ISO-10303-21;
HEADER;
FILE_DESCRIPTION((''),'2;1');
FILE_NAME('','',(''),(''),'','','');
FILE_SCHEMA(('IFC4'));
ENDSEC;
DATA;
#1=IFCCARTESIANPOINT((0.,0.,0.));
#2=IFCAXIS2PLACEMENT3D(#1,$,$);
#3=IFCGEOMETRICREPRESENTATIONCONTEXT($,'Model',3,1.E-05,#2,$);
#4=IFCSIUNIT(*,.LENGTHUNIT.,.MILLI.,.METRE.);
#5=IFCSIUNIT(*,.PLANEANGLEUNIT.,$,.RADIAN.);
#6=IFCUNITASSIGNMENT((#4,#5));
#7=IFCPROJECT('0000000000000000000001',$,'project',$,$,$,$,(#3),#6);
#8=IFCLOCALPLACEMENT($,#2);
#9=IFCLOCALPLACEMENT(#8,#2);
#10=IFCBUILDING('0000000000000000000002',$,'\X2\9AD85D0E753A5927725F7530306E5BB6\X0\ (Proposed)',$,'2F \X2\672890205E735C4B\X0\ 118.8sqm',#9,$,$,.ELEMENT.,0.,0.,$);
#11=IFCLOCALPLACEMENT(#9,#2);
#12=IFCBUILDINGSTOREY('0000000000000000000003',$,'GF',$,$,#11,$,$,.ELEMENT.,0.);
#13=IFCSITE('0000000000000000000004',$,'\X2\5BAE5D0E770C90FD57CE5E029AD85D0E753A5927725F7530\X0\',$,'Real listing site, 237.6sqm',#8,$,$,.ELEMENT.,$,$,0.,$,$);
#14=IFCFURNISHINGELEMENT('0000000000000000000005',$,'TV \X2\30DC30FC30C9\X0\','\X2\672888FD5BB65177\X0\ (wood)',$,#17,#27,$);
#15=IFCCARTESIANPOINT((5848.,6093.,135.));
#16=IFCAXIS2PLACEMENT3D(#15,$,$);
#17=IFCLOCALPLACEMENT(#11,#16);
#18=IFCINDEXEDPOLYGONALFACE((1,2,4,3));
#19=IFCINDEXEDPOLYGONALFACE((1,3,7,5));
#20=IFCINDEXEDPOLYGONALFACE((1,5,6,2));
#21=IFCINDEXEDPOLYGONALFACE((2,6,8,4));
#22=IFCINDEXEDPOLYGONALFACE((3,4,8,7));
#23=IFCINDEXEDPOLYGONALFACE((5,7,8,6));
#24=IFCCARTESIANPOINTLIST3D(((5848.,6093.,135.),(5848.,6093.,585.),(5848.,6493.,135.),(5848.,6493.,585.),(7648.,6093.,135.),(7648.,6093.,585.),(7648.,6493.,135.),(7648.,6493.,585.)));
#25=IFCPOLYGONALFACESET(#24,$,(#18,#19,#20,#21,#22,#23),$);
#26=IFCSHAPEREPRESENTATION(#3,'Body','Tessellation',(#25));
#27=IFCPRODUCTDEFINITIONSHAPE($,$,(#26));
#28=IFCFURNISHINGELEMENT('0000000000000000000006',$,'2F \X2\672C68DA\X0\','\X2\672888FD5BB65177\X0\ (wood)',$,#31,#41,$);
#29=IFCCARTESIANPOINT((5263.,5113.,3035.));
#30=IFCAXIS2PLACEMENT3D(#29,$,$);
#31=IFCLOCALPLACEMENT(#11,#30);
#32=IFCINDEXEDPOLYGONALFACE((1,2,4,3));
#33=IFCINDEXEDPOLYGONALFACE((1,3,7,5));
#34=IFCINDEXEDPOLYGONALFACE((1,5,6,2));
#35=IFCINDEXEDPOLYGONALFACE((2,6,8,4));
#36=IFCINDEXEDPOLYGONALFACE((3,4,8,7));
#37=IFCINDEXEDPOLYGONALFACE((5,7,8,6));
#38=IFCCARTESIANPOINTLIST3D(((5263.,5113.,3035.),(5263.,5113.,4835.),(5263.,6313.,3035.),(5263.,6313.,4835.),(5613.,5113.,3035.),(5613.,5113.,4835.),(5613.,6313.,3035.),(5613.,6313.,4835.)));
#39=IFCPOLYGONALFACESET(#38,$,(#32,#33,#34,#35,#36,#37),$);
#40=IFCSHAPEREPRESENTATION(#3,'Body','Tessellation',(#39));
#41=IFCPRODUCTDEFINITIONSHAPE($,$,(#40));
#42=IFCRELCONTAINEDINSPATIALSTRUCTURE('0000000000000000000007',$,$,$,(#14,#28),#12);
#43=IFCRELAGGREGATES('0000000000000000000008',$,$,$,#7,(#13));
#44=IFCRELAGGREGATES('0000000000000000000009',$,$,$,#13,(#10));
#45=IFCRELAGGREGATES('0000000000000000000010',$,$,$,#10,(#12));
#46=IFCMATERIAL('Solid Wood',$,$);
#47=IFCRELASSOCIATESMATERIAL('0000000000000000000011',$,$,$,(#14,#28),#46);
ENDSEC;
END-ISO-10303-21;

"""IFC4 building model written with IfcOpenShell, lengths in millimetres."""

from ifc_helpers import new_model, si_unit, frame, frame_2d, origin, place, context, project, spatial, rectangle, extrude, material, element, save


model = new_model("IFC4")

# Units and contexts
model_context = context("Model", 3, precision=1e-05, world=origin())
ifc_project = project(units=[si_unit("LENGTHUNIT", "METRE", prefix="MILLI"), si_unit("PLANEANGLEUNIT", "RADIAN")], contexts=[model_context])

# Site, building, storey
site_placement = place(None, origin())
site = spatial("IfcSite", under=ifc_project, at=site_placement, Name="宮崎県都城市高崎町大牟田", ObjectType="Real listing site, 237.6sqm", CompositionType="ELEMENT", RefElevation=0.0)
building_placement = place(site_placement, origin())
building = spatial("IfcBuilding", under=site, at=building_placement, Name="高崎町大牟田の家 (Proposed)", ObjectType="2F 木造平屋 118.8sqm", CompositionType="ELEMENT", ElevationOfRefHeight=0.0, ElevationOfTerrain=0.0)
storey_placement = place(building_placement, origin())
storey = spatial("IfcBuildingStorey", under=building, at=storey_placement, Name="GF", CompositionType="ELEMENT", Elevation=0.0)

# Shared definitions
ifc_material_1 = material(Name="Solid Wood")

# Furnishing elements
furnishing_1_placement = place(storey_placement, frame((5848.0, 6093.0, 135.0)))
element("IfcFurnishingElement", 1, at=furnishing_1_placement, inside=storey, material=ifc_material_1, Name="TV ボード", Description="木製家具 (wood)", context=model_context, shape_type="SweptSolid", body=[
    extrude(rectangle(XDim=1800.0, YDim=400.0, at=frame_2d((900.0, 200.0))), frame((5848.0, 6093.0, 135.0)), (0.0, 0.0, 1.0), 450.0),
])
furnishing_2_placement = place(storey_placement, frame((5263.0, 5113.0, 3035.0)))
element("IfcFurnishingElement", 2, at=furnishing_2_placement, inside=storey, material=ifc_material_1, Name="2F 本棚", Description="木製家具 (wood)", context=model_context, shape_type="SweptSolid", body=[
    extrude(rectangle(XDim=350.0, YDim=1200.0, at=frame_2d((175.0, 600.0))), frame((5263.0, 5113.0, 3035.0)), (0.0, 0.0, 1.0), 1800.0),
])

save(model, "model.ifc")
